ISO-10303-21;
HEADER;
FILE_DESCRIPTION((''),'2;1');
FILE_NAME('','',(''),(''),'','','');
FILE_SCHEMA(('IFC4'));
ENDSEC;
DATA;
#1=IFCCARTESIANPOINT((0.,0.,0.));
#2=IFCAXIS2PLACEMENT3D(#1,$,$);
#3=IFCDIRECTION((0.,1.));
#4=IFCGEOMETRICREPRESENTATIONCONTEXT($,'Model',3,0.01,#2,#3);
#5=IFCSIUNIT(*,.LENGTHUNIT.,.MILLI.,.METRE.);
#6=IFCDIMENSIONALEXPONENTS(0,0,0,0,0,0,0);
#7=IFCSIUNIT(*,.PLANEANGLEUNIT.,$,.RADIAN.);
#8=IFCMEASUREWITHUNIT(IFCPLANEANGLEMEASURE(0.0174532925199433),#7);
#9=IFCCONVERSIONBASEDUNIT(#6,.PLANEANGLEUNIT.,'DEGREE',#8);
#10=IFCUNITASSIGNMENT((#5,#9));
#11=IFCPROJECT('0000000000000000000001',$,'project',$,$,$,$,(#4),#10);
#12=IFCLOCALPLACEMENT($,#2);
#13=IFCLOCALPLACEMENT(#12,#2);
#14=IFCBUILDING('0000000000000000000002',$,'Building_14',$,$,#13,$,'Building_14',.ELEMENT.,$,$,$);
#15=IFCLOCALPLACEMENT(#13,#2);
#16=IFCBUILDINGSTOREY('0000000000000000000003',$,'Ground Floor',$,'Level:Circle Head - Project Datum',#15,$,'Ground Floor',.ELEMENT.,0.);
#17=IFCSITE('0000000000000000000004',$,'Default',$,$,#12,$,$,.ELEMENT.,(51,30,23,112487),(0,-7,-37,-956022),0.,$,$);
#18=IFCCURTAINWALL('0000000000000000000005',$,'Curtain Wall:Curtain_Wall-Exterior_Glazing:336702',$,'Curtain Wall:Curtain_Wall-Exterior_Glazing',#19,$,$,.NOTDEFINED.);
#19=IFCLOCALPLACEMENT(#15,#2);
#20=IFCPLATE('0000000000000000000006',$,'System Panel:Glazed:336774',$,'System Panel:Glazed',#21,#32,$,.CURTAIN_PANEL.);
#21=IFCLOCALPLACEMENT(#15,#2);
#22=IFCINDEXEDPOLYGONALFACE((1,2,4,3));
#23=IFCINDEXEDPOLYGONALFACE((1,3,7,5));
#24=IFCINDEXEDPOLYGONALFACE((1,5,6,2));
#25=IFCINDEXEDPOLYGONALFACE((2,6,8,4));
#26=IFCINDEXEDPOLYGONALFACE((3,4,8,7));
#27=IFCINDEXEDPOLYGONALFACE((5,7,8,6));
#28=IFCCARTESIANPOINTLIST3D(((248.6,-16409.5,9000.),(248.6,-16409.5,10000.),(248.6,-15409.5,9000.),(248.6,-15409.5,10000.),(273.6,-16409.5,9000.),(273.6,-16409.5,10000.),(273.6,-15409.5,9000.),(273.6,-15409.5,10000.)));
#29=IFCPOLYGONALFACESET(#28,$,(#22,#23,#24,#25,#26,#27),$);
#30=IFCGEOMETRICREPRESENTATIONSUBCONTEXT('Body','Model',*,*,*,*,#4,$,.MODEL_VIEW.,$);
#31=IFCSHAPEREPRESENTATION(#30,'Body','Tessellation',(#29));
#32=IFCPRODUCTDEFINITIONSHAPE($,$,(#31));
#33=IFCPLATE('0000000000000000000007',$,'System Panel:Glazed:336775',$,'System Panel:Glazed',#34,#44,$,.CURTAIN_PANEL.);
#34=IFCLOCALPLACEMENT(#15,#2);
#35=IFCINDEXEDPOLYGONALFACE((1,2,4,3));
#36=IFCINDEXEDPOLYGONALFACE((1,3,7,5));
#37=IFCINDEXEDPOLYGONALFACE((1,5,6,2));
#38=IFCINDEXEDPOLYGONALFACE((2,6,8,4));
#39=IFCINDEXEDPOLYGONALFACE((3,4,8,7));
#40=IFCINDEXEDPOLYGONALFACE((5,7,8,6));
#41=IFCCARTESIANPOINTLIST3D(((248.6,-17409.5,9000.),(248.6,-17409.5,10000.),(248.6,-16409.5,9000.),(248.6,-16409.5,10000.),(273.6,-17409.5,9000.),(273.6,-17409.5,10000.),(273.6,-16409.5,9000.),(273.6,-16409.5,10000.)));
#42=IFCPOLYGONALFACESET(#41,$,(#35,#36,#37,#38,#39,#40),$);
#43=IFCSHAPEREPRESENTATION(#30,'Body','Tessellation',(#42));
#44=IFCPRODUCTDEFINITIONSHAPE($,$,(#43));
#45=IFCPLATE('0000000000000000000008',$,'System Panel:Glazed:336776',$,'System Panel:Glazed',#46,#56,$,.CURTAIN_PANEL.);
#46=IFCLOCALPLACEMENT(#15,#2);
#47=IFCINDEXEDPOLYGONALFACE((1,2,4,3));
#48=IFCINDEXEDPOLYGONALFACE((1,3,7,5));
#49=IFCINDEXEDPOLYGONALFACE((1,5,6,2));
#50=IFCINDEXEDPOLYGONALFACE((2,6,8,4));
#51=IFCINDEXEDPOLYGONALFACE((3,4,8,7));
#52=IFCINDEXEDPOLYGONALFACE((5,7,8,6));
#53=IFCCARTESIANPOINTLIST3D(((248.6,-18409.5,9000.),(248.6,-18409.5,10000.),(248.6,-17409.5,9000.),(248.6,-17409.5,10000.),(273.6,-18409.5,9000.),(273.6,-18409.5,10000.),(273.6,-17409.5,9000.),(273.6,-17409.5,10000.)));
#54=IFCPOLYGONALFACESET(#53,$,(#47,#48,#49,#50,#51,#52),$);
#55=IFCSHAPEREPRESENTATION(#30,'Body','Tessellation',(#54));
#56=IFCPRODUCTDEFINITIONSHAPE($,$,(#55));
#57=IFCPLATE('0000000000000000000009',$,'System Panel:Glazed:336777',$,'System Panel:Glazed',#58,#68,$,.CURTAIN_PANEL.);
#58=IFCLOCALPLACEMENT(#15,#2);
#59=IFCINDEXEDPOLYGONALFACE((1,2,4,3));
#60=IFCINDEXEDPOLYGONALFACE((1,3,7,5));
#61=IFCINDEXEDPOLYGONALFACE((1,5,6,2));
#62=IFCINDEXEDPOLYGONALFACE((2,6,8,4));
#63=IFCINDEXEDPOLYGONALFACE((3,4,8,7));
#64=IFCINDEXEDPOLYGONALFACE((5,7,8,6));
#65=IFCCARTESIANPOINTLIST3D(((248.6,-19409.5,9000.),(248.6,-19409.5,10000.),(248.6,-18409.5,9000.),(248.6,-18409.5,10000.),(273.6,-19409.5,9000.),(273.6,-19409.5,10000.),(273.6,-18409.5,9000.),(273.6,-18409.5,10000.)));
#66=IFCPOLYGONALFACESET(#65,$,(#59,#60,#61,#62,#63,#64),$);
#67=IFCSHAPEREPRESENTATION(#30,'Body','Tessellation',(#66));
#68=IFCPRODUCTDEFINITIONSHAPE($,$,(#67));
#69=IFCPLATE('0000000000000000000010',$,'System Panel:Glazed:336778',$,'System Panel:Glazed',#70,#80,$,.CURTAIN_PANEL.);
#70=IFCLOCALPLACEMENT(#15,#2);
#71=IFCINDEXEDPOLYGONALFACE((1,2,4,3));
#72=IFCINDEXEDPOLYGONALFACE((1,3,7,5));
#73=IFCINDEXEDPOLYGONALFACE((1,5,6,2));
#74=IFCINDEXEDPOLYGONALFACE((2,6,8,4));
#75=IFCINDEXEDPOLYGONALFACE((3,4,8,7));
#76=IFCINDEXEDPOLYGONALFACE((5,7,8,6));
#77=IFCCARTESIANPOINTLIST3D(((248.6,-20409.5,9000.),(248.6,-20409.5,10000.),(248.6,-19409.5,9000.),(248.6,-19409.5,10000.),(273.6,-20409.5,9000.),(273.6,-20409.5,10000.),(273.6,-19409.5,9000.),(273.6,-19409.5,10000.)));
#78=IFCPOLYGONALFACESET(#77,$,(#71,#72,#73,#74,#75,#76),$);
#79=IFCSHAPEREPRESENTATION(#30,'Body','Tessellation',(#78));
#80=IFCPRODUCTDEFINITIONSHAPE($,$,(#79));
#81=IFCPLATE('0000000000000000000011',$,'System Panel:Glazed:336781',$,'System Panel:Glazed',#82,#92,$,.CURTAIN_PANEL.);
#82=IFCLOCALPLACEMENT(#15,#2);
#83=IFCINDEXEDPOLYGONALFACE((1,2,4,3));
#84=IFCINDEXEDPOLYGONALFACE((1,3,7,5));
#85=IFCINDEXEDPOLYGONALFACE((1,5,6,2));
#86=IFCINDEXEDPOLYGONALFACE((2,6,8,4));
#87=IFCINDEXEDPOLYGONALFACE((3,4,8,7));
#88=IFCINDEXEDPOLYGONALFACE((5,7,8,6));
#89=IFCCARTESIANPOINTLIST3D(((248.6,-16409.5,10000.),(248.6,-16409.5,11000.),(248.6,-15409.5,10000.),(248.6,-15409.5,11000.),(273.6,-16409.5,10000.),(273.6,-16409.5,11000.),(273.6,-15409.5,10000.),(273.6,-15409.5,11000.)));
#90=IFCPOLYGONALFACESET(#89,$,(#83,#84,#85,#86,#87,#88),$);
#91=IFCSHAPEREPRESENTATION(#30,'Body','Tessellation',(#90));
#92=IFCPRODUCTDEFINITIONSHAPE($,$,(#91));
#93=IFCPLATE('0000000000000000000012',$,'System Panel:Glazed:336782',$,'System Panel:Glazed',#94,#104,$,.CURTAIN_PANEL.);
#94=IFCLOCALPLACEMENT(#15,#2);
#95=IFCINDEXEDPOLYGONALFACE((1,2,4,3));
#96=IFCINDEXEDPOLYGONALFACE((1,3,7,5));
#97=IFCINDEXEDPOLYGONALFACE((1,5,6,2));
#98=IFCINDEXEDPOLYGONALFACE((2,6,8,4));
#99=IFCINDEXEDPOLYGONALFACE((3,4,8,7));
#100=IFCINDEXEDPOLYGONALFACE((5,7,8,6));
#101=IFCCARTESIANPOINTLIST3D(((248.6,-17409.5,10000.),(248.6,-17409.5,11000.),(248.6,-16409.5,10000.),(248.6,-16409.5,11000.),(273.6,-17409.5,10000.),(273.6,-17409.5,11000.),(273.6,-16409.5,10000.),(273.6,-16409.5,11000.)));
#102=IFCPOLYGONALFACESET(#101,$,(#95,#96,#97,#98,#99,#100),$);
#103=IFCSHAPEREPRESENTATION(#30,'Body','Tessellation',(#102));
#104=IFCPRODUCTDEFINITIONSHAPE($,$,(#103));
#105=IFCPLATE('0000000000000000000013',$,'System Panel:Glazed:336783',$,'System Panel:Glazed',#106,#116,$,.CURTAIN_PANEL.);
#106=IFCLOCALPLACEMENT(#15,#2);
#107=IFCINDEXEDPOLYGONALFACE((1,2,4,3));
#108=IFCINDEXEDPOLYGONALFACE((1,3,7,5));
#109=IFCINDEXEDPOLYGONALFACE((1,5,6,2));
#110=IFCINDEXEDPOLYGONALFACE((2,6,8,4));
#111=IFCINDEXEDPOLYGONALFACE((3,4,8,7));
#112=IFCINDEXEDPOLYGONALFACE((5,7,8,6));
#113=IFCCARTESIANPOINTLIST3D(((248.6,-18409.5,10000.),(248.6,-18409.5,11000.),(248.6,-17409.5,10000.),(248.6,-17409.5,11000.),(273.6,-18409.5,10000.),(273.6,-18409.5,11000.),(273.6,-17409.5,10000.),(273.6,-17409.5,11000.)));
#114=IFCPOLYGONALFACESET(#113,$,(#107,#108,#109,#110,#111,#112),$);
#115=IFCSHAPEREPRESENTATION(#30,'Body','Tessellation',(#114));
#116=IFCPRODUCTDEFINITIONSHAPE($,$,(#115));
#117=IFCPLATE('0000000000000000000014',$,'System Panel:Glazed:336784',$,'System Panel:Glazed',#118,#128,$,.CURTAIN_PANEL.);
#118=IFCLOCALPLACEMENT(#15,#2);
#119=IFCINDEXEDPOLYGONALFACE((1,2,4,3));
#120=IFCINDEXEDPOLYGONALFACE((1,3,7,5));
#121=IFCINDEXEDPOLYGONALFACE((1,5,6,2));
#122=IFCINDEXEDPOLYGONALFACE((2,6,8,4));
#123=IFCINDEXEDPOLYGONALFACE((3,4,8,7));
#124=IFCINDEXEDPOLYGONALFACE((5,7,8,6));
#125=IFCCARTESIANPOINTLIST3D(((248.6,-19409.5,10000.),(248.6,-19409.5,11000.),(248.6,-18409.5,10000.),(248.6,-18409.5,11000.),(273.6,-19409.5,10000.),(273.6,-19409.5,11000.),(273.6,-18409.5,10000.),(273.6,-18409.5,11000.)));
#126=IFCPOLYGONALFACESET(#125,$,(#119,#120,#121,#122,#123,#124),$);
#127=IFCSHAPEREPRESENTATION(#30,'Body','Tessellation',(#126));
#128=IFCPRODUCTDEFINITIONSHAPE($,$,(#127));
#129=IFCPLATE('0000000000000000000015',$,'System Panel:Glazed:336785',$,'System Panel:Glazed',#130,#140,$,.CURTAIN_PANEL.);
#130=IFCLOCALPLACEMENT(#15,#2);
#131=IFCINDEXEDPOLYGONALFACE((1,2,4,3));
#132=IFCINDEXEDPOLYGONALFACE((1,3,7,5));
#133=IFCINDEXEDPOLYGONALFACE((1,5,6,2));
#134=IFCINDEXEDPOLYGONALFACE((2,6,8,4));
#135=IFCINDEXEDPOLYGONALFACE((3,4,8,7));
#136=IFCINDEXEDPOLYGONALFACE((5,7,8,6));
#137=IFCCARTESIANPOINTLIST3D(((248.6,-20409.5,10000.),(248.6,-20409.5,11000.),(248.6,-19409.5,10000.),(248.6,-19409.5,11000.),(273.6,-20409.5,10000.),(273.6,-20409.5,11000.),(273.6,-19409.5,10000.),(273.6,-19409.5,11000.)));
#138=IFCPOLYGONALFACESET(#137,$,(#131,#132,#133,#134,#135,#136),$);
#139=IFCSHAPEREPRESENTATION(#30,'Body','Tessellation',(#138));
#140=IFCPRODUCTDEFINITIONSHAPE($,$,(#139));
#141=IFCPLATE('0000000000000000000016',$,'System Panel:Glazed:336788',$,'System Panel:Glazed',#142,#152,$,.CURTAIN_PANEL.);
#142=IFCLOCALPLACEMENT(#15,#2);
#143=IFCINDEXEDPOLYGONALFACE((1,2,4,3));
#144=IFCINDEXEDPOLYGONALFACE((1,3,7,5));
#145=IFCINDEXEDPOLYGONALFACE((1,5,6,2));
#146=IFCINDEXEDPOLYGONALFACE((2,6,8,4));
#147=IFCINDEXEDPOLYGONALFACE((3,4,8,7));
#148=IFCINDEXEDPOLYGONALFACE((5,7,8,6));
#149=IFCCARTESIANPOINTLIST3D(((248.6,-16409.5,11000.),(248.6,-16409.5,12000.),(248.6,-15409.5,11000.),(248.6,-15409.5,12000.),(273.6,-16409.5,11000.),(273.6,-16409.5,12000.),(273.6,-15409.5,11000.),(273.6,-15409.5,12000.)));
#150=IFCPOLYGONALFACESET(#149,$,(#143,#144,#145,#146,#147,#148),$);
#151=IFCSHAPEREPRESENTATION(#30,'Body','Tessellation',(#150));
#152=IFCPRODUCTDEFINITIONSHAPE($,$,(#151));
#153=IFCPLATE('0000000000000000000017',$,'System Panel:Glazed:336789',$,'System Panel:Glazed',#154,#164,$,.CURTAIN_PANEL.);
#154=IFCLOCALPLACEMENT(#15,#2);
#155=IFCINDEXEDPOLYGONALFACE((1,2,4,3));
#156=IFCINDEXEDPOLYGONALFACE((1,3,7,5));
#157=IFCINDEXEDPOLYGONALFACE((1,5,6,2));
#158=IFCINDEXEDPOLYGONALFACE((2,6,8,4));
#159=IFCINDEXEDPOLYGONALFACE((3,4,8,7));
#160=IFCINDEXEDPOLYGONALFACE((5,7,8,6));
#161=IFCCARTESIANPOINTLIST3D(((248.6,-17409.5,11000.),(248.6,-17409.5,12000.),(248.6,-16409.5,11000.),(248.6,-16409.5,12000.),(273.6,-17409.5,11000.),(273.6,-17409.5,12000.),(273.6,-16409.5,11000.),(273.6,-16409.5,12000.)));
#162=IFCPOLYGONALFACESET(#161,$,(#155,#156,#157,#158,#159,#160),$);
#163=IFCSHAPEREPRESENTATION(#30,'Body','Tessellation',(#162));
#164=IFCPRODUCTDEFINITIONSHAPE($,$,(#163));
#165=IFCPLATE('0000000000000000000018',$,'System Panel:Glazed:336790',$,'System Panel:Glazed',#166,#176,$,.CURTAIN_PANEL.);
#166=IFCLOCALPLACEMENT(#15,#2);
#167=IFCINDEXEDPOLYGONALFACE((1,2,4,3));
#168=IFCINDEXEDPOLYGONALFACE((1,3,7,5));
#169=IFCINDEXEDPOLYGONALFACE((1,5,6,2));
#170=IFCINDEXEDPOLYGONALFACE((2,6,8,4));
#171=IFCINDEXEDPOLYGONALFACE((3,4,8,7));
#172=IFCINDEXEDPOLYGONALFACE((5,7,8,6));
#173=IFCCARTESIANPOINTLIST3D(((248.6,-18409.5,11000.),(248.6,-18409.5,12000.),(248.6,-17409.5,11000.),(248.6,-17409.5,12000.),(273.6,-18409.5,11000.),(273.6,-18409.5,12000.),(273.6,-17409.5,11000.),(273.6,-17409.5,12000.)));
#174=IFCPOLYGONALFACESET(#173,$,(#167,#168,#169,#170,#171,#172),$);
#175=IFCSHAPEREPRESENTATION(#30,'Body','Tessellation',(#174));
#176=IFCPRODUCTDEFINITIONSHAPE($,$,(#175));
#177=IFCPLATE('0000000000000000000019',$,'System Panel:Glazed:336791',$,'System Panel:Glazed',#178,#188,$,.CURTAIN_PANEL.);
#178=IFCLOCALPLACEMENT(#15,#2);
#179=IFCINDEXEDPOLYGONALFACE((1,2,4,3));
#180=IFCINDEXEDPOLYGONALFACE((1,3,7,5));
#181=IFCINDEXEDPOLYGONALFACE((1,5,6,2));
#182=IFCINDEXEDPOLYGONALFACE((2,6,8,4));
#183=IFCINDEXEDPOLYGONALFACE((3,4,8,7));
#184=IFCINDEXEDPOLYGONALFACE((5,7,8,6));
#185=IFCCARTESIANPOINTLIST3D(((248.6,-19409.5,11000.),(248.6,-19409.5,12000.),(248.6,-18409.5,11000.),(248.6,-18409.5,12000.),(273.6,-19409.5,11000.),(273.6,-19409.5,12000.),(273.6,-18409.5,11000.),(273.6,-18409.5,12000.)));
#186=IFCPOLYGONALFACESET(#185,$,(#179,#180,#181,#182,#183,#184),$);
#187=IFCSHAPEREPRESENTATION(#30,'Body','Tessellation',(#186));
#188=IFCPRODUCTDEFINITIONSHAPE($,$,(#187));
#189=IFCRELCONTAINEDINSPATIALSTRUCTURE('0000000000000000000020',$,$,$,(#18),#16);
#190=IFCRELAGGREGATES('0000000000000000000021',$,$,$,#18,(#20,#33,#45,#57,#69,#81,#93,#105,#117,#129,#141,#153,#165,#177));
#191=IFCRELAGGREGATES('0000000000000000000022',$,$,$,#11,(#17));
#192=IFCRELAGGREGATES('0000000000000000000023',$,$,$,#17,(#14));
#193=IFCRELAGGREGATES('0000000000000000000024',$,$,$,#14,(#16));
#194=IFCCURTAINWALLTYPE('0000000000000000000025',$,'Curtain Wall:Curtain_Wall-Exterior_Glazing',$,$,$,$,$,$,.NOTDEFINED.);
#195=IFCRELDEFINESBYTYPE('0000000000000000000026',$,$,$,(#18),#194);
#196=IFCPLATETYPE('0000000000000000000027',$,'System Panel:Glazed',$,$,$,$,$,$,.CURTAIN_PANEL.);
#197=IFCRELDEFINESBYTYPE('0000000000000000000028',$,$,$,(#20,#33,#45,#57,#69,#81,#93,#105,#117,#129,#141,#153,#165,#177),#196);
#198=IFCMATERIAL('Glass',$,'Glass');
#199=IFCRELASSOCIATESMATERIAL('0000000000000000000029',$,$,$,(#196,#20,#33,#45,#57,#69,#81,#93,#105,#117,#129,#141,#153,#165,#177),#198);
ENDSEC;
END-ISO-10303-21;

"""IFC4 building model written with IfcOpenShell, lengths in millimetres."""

from ifc_helpers import new_model, entity, si_unit, converted_unit, direction, frame, origin, place, context, subcontext, project, spatial, indexed_curve, outline, extrude, source, transform, mapped, material, type_object, type_shapes, element, aggregate, save


model = new_model("IFC4")

# Units and contexts
model_context = context("Model", 3, precision=0.01, world=origin(), true_north=direction((0.0, 1.0)))
body_context = subcontext(model_context, "Body", "Model", "MODEL_VIEW")
ifc_project = project(units=[si_unit("LENGTHUNIT", "METRE", prefix="MILLI"), converted_unit("PLANEANGLEUNIT", "DEGREE", entity("IfcPlaneAngleMeasure", 0.0174532925199433), si_unit("PLANEANGLEUNIT", "RADIAN"), dimensions=[0, 0, 0, 0, 0, 0, 0])], contexts=[model_context])

# Site, building, storey
site_placement = place(None, origin())
site = spatial("IfcSite", under=ifc_project, at=site_placement, Name="Default", CompositionType="ELEMENT", RefLatitude=(51, 30, 23, 112487), RefLongitude=(0, -7, -37, -956022), RefElevation=0.0)
building_placement = place(site_placement, origin())
building = spatial("IfcBuilding", under=site, at=building_placement, Name="Building_14", LongName="Building_14", CompositionType="ELEMENT")
storey_placement = place(building_placement, origin())
storey = spatial("IfcBuildingStorey", under=building, at=storey_placement, Name="Ground Floor", ObjectType="Level:Circle Head - Project Datum", LongName="Ground Floor", CompositionType="ELEMENT", Elevation=0.0)

# Curtain wall, plates
curtain_wall_type = type_object("IfcCurtainWallType", Name="Curtain Wall:Curtain_Wall-Exterior_Glazing", PredefinedType="NOTDEFINED")
curtain_wall_1_placement = place(storey_placement, origin())
curtain_wall_1 = element("IfcCurtainWall", 1, at=curtain_wall_1_placement, inside=storey, type_object=curtain_wall_type, Name="Curtain Wall:Curtain_Wall-Exterior_Glazing:336702", ObjectType="Curtain Wall:Curtain_Wall-Exterior_Glazing", PredefinedType="NOTDEFINED")
ifc_material = material(Name="Glass", Category="Glass")
plate_type_1 = type_object("IfcPlateType", Name="System Panel:Glazed", PredefinedType="CURTAIN_PANEL", material=ifc_material)
shared_shape_1 = source(origin(), body_context, "Body", "SweptSolid", [
    extrude(outline(indexed_curve([(-12.5, -500.0), (12.5, -500.0), (12.5, 500.0), (-12.5, 500.0), (-12.5, -500.0)], self_intersect=False)), frame((0.0, -37.0, 0.0), z_axis=(0.0, 0.0, 1.0), x_axis=(0.0, 1.0, 0.0)), (0.0, 0.0, 1.0), 1000.0),
])
type_shapes(plate_type_1, [shared_shape_1])
plate_1_placement = place(curtain_wall_1_placement, frame((298.1, -15909.5, 9000.0), z_axis=(0.0, 0.0, 1.0), x_axis=(0.0, -1.0, 0.0)))
plate_1 = element("IfcPlate", 2, at=plate_1_placement, type_object=plate_type_1, material=ifc_material, Name="System Panel:Glazed:336774", ObjectType="System Panel:Glazed", PredefinedType="CURTAIN_PANEL", context=body_context, shape_type="MappedRepresentation", body=[
    mapped(shared_shape_1, transform((0.0, 0.0, 0.0), scale=1.0)),
])
plate_2_placement = place(curtain_wall_1_placement, frame((298.1, -16909.5, 9000.0), z_axis=(0.0, 0.0, 1.0), x_axis=(0.0, -1.0, 0.0)))
plate_2 = element("IfcPlate", 3, at=plate_2_placement, type_object=plate_type_1, material=ifc_material, Name="System Panel:Glazed:336775", ObjectType="System Panel:Glazed", PredefinedType="CURTAIN_PANEL", context=body_context, shape_type="MappedRepresentation", body=[
    mapped(shared_shape_1, transform((0.0, 0.0, 0.0), scale=1.0)),
])
plate_3_placement = place(curtain_wall_1_placement, frame((298.1, -17909.5, 9000.0), z_axis=(0.0, 0.0, 1.0), x_axis=(0.0, -1.0, 0.0)))
plate_3 = element("IfcPlate", 4, at=plate_3_placement, type_object=plate_type_1, material=ifc_material, Name="System Panel:Glazed:336776", ObjectType="System Panel:Glazed", PredefinedType="CURTAIN_PANEL", context=body_context, shape_type="MappedRepresentation", body=[
    mapped(shared_shape_1, transform((0.0, 0.0, 0.0), scale=1.0)),
])
plate_4_placement = place(curtain_wall_1_placement, frame((298.1, -18909.5, 9000.0), z_axis=(0.0, 0.0, 1.0), x_axis=(0.0, -1.0, 0.0)))
plate_4 = element("IfcPlate", 5, at=plate_4_placement, type_object=plate_type_1, material=ifc_material, Name="System Panel:Glazed:336777", ObjectType="System Panel:Glazed", PredefinedType="CURTAIN_PANEL", context=body_context, shape_type="MappedRepresentation", body=[
    mapped(shared_shape_1, transform((0.0, 0.0, 0.0), scale=1.0)),
])
plate_5_placement = place(curtain_wall_1_placement, frame((298.1, -19909.5, 9000.0), z_axis=(0.0, 0.0, 1.0), x_axis=(0.0, -1.0, 0.0)))
plate_5 = element("IfcPlate", 6, at=plate_5_placement, type_object=plate_type_1, material=ifc_material, Name="System Panel:Glazed:336778", ObjectType="System Panel:Glazed", PredefinedType="CURTAIN_PANEL", context=body_context, shape_type="MappedRepresentation", body=[
    mapped(shared_shape_1, transform((0.0, 0.0, 0.0), scale=1.0)),
])
plate_6_placement = place(curtain_wall_1_placement, frame((298.1, -15909.5, 10000.0), z_axis=(0.0, 0.0, 1.0), x_axis=(0.0, -1.0, 0.0)))
plate_6 = element("IfcPlate", 7, at=plate_6_placement, type_object=plate_type_1, material=ifc_material, Name="System Panel:Glazed:336781", ObjectType="System Panel:Glazed", PredefinedType="CURTAIN_PANEL", context=body_context, shape_type="MappedRepresentation", body=[
    mapped(shared_shape_1, transform((0.0, 0.0, 0.0), scale=1.0)),
])
plate_7_placement = place(curtain_wall_1_placement, frame((298.1, -16909.5, 10000.0), z_axis=(0.0, 0.0, 1.0), x_axis=(0.0, -1.0, 0.0)))
plate_7 = element("IfcPlate", 8, at=plate_7_placement, type_object=plate_type_1, material=ifc_material, Name="System Panel:Glazed:336782", ObjectType="System Panel:Glazed", PredefinedType="CURTAIN_PANEL", context=body_context, shape_type="MappedRepresentation", body=[
    mapped(shared_shape_1, transform((0.0, 0.0, 0.0), scale=1.0)),
])
plate_8_placement = place(curtain_wall_1_placement, frame((298.1, -17909.5, 10000.0), z_axis=(0.0, 0.0, 1.0), x_axis=(0.0, -1.0, 0.0)))
plate_8 = element("IfcPlate", 9, at=plate_8_placement, type_object=plate_type_1, material=ifc_material, Name="System Panel:Glazed:336783", ObjectType="System Panel:Glazed", PredefinedType="CURTAIN_PANEL", context=body_context, shape_type="MappedRepresentation", body=[
    mapped(shared_shape_1, transform((0.0, 0.0, 0.0), scale=1.0)),
])
plate_9_placement = place(curtain_wall_1_placement, frame((298.1, -18909.5, 10000.0), z_axis=(0.0, 0.0, 1.0), x_axis=(0.0, -1.0, 0.0)))
plate_9 = element("IfcPlate", 10, at=plate_9_placement, type_object=plate_type_1, material=ifc_material, Name="System Panel:Glazed:336784", ObjectType="System Panel:Glazed", PredefinedType="CURTAIN_PANEL", context=body_context, shape_type="MappedRepresentation", body=[
    mapped(shared_shape_1, transform((0.0, 0.0, 0.0), scale=1.0)),
])
plate_10_placement = place(curtain_wall_1_placement, frame((298.1, -19909.5, 10000.0), z_axis=(0.0, 0.0, 1.0), x_axis=(0.0, -1.0, 0.0)))
plate_10 = element("IfcPlate", 11, at=plate_10_placement, type_object=plate_type_1, material=ifc_material, Name="System Panel:Glazed:336785", ObjectType="System Panel:Glazed", PredefinedType="CURTAIN_PANEL", context=body_context, shape_type="MappedRepresentation", body=[
    mapped(shared_shape_1, transform((0.0, 0.0, 0.0), scale=1.0)),
])
plate_11_placement = place(curtain_wall_1_placement, frame((298.1, -15909.5, 11000.0), z_axis=(0.0, 0.0, 1.0), x_axis=(0.0, -1.0, 0.0)))
plate_11 = element("IfcPlate", 12, at=plate_11_placement, type_object=plate_type_1, material=ifc_material, Name="System Panel:Glazed:336788", ObjectType="System Panel:Glazed", PredefinedType="CURTAIN_PANEL", context=body_context, shape_type="MappedRepresentation", body=[
    mapped(shared_shape_1, transform((0.0, 0.0, 0.0), scale=1.0)),
])
plate_12_placement = place(curtain_wall_1_placement, frame((298.1, -16909.5, 11000.0), z_axis=(0.0, 0.0, 1.0), x_axis=(0.0, -1.0, 0.0)))
plate_12 = element("IfcPlate", 13, at=plate_12_placement, type_object=plate_type_1, material=ifc_material, Name="System Panel:Glazed:336789", ObjectType="System Panel:Glazed", PredefinedType="CURTAIN_PANEL", context=body_context, shape_type="MappedRepresentation", body=[
    mapped(shared_shape_1, transform((0.0, 0.0, 0.0), scale=1.0)),
])
plate_13_placement = place(curtain_wall_1_placement, frame((298.1, -17909.5, 11000.0), z_axis=(0.0, 0.0, 1.0), x_axis=(0.0, -1.0, 0.0)))
plate_13 = element("IfcPlate", 14, at=plate_13_placement, type_object=plate_type_1, material=ifc_material, Name="System Panel:Glazed:336790", ObjectType="System Panel:Glazed", PredefinedType="CURTAIN_PANEL", context=body_context, shape_type="MappedRepresentation", body=[
    mapped(shared_shape_1, transform((0.0, 0.0, 0.0), scale=1.0)),
])
plate_14_placement = place(curtain_wall_1_placement, frame((298.1, -18909.5, 11000.0), z_axis=(0.0, 0.0, 1.0), x_axis=(0.0, -1.0, 0.0)))
plate_14 = element("IfcPlate", 15, at=plate_14_placement, type_object=plate_type_1, material=ifc_material, Name="System Panel:Glazed:336791", ObjectType="System Panel:Glazed", PredefinedType="CURTAIN_PANEL", context=body_context, shape_type="MappedRepresentation", body=[
    mapped(shared_shape_1, transform((0.0, 0.0, 0.0), scale=1.0)),
])

aggregate(curtain_wall_1, [plate_1, plate_2, plate_3, plate_4, plate_5, plate_6, plate_7, plate_8, plate_9, plate_10, plate_11, plate_12, plate_13, plate_14])

save(model, "model.ifc")
